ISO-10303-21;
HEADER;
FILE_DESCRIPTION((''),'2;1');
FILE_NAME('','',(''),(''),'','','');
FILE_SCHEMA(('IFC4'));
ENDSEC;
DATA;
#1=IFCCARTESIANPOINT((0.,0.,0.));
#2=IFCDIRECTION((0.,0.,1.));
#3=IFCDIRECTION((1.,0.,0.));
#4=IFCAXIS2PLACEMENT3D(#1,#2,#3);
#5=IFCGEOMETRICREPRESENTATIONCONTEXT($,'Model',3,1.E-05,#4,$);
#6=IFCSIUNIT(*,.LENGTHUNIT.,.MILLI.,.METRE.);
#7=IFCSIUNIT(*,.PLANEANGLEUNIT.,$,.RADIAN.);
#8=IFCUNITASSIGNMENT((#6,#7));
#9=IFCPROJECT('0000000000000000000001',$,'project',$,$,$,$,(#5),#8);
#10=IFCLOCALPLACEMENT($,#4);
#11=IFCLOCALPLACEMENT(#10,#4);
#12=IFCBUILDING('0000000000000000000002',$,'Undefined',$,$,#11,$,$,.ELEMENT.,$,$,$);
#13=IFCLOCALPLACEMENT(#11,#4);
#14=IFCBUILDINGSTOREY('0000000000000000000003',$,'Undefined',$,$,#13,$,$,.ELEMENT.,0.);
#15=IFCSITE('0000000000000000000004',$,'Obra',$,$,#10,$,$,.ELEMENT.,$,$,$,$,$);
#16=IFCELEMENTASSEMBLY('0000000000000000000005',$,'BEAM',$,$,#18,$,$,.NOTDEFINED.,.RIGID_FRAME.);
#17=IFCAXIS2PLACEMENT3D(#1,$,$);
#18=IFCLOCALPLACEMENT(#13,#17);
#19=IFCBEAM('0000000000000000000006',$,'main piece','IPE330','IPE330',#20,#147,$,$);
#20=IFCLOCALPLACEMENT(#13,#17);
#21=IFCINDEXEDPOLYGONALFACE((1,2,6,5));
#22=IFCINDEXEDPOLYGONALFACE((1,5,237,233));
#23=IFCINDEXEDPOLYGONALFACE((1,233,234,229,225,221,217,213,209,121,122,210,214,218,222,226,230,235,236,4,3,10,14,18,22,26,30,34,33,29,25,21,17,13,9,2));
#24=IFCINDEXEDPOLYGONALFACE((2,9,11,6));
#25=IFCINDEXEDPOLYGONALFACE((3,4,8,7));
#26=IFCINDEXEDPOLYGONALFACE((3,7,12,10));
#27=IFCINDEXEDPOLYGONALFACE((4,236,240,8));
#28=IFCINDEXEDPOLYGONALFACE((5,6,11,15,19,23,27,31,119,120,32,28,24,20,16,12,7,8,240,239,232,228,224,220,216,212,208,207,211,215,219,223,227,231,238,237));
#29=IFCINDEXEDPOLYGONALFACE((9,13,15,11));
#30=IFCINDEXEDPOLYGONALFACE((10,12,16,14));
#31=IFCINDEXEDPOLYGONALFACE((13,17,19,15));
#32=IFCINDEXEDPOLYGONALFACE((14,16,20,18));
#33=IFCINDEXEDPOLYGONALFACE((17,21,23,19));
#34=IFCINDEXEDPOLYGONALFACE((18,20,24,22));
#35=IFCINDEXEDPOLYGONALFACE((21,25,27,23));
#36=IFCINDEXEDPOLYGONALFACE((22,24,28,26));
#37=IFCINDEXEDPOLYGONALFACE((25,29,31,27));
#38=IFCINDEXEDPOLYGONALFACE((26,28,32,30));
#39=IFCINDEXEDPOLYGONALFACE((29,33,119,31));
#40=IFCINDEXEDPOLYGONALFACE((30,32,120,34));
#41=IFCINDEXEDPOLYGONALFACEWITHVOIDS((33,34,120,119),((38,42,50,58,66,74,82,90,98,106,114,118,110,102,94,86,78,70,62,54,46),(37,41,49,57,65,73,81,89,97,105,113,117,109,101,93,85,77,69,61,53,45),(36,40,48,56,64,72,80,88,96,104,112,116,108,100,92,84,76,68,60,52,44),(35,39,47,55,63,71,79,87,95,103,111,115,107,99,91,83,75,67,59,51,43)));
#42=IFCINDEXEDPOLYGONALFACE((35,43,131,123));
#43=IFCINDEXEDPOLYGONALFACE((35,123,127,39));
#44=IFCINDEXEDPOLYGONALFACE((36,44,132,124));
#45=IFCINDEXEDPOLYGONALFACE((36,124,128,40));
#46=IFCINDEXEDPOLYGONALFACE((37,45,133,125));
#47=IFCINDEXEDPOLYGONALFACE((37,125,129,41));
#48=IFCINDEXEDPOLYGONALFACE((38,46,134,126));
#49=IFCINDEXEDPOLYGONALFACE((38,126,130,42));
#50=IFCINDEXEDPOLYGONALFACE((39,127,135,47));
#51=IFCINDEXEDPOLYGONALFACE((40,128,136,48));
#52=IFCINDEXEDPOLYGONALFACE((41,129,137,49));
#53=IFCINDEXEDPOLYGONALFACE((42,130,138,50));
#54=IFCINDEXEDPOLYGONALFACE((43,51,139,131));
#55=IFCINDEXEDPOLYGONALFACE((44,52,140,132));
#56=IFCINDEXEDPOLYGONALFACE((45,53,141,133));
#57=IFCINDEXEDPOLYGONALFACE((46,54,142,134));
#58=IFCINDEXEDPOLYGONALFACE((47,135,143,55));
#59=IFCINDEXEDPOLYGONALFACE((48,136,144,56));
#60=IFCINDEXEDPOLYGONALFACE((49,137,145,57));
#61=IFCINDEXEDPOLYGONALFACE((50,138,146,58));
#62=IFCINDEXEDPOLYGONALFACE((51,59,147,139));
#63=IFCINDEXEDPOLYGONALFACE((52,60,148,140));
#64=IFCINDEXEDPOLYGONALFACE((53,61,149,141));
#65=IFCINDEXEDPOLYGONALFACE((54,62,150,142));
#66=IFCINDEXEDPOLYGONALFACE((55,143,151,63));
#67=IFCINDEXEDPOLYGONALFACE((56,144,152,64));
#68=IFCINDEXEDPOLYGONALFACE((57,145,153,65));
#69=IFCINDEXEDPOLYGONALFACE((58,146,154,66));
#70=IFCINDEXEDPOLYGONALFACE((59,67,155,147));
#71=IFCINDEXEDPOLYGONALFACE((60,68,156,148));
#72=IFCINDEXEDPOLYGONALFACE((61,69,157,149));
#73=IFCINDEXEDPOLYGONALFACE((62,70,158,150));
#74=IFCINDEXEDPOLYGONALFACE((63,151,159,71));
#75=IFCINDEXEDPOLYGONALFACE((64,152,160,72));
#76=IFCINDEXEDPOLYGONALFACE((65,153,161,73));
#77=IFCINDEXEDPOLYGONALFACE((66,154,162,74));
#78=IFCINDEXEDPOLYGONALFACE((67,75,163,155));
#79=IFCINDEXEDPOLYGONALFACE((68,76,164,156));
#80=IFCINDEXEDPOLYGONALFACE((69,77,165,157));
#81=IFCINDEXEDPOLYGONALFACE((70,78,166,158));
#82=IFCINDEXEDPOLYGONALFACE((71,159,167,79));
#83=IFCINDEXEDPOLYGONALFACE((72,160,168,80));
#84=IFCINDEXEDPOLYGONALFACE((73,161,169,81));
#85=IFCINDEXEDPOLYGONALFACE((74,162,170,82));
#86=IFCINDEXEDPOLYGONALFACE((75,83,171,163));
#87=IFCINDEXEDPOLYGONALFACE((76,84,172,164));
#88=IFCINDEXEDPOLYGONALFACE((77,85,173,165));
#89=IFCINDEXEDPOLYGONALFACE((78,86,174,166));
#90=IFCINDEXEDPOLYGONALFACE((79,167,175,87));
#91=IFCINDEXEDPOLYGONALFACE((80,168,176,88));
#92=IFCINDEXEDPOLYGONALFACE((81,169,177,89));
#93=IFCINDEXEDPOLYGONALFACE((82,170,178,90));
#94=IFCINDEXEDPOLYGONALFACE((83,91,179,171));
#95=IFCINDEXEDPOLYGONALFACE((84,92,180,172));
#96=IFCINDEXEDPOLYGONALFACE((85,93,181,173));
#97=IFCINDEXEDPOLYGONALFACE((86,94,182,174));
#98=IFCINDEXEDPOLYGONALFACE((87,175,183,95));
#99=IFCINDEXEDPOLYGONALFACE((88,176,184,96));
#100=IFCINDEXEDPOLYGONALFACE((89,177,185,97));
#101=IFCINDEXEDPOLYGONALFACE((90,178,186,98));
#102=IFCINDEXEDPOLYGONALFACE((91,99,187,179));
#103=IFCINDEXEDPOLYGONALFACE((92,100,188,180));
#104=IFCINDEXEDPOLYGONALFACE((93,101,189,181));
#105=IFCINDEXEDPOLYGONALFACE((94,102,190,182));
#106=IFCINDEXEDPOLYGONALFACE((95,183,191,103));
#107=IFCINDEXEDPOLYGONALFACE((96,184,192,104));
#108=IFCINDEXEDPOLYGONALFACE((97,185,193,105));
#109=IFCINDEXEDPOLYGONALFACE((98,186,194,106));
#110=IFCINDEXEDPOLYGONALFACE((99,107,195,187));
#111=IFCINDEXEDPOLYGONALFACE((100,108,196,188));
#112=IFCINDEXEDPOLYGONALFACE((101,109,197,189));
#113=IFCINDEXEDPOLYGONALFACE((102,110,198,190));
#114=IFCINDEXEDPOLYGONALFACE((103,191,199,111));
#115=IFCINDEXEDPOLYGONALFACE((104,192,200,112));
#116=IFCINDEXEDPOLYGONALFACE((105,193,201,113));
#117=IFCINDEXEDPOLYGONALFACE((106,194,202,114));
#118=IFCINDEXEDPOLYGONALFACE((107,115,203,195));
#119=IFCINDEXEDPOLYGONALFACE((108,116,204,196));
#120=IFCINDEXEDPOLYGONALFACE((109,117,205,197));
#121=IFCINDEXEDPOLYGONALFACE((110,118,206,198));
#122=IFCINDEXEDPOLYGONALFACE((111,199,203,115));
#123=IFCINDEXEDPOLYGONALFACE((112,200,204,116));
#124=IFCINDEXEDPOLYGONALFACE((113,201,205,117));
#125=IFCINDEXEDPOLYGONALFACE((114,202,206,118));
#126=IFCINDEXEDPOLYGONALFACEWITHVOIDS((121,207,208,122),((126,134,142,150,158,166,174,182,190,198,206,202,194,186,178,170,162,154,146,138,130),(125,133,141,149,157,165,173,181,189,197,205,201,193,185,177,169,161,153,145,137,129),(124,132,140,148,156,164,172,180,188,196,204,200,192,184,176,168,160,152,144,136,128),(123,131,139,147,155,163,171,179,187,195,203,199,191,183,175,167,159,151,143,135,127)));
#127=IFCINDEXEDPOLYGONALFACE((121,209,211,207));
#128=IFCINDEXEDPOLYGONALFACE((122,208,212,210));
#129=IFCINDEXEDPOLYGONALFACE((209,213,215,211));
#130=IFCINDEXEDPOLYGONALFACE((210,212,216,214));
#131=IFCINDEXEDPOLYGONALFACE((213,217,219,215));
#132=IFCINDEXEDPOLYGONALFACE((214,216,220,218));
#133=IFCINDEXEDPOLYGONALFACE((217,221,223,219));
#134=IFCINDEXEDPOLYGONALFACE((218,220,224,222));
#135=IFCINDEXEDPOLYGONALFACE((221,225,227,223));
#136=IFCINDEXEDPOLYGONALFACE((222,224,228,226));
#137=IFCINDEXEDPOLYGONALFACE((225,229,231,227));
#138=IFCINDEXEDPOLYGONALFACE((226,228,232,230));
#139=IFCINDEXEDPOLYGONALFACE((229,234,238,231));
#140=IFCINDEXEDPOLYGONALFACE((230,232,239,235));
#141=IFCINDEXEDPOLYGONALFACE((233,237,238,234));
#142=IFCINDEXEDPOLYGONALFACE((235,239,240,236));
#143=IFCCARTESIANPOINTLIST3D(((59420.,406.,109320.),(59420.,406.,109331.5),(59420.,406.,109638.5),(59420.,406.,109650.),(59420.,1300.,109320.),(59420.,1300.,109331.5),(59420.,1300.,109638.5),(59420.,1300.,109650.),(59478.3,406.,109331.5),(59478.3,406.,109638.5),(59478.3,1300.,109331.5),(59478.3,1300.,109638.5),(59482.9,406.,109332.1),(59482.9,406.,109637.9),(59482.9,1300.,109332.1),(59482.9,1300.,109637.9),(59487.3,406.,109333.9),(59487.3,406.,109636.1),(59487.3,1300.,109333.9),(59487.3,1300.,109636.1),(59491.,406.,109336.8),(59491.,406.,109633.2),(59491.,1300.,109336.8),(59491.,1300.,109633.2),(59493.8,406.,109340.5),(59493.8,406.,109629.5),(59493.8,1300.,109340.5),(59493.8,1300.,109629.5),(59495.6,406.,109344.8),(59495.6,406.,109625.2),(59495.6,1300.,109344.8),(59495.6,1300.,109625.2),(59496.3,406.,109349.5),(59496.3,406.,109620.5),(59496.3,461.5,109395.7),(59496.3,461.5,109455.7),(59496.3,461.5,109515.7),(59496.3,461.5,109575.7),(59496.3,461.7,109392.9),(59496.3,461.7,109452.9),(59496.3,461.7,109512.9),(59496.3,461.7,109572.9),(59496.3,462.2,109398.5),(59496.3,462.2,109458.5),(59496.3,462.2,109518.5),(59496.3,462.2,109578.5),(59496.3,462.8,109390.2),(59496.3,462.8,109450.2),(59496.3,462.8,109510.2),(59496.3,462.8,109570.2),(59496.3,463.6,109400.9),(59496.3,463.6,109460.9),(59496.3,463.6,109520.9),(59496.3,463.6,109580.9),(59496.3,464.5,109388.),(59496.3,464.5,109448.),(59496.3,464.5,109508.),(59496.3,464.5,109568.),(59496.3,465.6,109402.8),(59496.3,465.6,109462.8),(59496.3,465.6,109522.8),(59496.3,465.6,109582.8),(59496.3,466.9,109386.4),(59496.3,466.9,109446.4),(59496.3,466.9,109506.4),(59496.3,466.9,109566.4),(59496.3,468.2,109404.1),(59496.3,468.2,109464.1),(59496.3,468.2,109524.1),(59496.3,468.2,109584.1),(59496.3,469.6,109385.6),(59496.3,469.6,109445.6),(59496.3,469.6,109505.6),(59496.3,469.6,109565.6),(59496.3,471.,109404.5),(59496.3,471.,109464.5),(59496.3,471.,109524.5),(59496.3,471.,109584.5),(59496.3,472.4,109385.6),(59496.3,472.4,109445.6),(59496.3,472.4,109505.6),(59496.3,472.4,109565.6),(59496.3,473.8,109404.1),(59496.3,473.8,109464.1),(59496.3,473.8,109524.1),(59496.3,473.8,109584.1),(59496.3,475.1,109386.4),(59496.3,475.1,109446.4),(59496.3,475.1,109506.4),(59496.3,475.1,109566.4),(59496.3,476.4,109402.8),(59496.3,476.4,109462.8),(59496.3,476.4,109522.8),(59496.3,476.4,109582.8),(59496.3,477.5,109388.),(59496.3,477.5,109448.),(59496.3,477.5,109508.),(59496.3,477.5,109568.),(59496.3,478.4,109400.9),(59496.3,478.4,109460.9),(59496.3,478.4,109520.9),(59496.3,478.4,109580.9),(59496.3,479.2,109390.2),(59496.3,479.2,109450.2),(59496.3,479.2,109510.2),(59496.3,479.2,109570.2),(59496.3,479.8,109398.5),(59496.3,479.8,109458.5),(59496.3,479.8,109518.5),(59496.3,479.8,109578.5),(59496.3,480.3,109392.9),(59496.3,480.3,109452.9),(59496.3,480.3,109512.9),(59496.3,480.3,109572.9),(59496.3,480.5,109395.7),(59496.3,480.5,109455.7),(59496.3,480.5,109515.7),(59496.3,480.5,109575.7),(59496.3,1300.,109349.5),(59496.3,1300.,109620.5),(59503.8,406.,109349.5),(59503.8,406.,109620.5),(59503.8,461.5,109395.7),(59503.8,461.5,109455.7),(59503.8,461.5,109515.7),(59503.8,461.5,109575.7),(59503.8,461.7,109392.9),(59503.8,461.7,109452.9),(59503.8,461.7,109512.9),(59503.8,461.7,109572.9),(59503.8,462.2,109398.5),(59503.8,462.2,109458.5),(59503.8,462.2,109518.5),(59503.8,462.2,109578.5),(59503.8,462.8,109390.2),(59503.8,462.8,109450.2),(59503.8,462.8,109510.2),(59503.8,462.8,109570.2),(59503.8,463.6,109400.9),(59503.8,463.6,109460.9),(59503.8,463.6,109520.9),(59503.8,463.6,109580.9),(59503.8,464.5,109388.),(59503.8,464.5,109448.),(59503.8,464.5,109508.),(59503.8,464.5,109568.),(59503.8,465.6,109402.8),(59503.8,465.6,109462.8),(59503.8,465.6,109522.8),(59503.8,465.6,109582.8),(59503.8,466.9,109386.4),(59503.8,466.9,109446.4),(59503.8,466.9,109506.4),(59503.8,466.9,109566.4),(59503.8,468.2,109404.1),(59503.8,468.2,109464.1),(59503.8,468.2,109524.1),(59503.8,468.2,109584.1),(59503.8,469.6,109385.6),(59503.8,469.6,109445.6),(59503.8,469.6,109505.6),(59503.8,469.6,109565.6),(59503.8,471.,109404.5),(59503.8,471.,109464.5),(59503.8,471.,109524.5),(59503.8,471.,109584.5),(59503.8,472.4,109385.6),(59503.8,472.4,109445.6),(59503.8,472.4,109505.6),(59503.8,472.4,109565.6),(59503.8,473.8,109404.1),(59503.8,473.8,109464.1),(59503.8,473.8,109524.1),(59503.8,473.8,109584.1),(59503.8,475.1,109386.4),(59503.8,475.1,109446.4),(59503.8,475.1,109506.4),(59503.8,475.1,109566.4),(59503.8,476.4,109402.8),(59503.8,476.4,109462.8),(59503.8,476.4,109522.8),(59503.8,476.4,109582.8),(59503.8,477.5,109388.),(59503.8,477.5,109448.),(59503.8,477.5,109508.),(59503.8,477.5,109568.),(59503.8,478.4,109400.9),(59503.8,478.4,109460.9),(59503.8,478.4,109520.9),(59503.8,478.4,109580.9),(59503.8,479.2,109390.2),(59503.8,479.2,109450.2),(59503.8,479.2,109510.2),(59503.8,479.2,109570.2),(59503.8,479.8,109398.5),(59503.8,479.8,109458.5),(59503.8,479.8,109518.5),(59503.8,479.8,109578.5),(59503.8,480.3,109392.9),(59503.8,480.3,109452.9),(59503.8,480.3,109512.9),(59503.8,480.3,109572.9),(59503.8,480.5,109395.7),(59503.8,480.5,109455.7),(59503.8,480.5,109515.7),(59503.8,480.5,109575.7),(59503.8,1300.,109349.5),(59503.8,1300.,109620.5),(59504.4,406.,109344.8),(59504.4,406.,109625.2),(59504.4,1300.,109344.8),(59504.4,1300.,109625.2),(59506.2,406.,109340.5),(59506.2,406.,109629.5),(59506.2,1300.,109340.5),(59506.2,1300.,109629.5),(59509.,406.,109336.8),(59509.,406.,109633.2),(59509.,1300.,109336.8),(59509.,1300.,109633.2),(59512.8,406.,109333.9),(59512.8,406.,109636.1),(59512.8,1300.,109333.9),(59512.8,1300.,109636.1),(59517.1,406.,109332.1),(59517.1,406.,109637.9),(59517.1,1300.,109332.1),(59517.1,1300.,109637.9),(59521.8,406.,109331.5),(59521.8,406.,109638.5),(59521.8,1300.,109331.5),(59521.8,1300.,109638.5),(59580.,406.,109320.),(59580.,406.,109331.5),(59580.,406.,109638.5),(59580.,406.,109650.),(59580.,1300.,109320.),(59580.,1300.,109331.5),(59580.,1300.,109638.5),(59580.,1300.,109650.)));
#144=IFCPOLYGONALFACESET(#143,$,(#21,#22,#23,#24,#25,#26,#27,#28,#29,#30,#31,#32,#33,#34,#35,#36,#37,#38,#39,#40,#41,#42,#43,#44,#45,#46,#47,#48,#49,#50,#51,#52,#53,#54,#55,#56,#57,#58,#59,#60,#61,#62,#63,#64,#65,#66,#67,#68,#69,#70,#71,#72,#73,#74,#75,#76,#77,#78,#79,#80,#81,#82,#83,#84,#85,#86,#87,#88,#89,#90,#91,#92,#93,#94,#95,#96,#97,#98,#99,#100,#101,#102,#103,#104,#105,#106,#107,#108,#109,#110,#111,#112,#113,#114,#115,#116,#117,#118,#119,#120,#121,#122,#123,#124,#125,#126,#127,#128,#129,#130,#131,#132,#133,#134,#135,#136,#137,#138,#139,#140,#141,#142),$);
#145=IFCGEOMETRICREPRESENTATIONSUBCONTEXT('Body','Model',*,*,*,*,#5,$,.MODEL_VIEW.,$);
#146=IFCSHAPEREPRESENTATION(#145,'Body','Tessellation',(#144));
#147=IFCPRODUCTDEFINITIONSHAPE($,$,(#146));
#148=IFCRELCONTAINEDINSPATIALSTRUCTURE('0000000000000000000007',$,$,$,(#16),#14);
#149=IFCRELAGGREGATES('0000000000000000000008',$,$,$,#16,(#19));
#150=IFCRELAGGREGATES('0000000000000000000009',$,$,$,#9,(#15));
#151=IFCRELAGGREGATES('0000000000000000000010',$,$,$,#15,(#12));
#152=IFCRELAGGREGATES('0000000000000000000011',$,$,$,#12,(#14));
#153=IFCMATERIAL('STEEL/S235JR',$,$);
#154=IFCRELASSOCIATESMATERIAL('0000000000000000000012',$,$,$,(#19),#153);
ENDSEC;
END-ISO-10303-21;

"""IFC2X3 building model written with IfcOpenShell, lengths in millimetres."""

from ifc_helpers import new_model, si_unit, frame, origin_with_axes, origin_2d_with_axis, place, context, subcontext, project, spatial, circle, i_section, extrude, clip, halfspace, source, transform, mapped, material, element, aggregate, save


model = new_model("IFC2X3")

# Units and contexts
model_context = context("Model", 3, precision=1e-05, world=origin_with_axes())
body_context = subcontext(model_context, "Body", "Model", "MODEL_VIEW")
ifc_project = project(units=[si_unit("LENGTHUNIT", "METRE", prefix="MILLI"), si_unit("PLANEANGLEUNIT", "RADIAN")], contexts=[model_context])

# Site, building, storey
site_placement = place(None, origin_with_axes())
site = spatial("IfcSite", under=ifc_project, at=site_placement, Name="Obra", CompositionType="ELEMENT")
building_placement = place(site_placement, origin_with_axes())
building = spatial("IfcBuilding", under=site, at=building_placement, Name="Undefined", CompositionType="ELEMENT")
storey_placement = place(building_placement, origin_with_axes())
storey = spatial("IfcBuildingStorey", under=building, at=storey_placement, Name="Undefined", CompositionType="ELEMENT", Elevation=0.0)

# Element assembly, beam, opening
ifc_material_1 = material(Name="STEEL/S235JR")
shared_shape_1 = source(origin_with_axes(), body_context, "Body", "SweptSolid", [
    extrude(circle(Radius=9.5, at=origin_2d_with_axis()), frame((0.0, -3.9, 0.0), z_axis=(0.0, 1.0, 0.0), x_axis=(1.0, 0.0, 0.0)), (0.0, 0.0, 1.0), 7.7),
])
assembly_1_placement = place(storey_placement, origin_with_axes())
assembly_1 = element("IfcElementAssembly", 1, at=assembly_1_placement, inside=storey, Name="BEAM", AssemblyPlace="NOTDEFINED", PredefinedType="RIGID_FRAME")
beam_1_placement = place(assembly_1_placement, frame((59500.0, 400.0, 109485.0), z_axis=(0.0, 0.0, 1.0), x_axis=(0.0, 1.0, 0.0)))
beam_1 = element("IfcBeam", 2, at=beam_1_placement, material=ifc_material_1, Name="main piece", Description="IPE330", ObjectType="IPE330", context=body_context, shape_type="Clipping", body=[
    clip(extrude(i_section(OverallWidth=160.0, OverallDepth=330.0, WebThickness=7.5, FlangeThickness=11.5, FilletRadius=18.0, at=origin_2d_with_axis()), frame((900.0, 0.0, 0.0), z_axis=(-1.0, 0.0, 0.0), x_axis=(0.0, -1.0, 0.0)), (0.0, 0.0, 1.0), 894.0), halfspace(frame((6.0, 0.0, -220.0), z_axis=(1.0, 0.0, 0.0), x_axis=(0.0, -1.0, 0.0)), True)),
])
opening_1_placement = place(assembly_1_placement, frame((59500.0, 471.0, 109395.0), z_axis=(0.0, -1.0, 0.0), x_axis=(0.0, 0.0, 1.0)))
element("IfcOpeningElement", 3, at=opening_1_placement, cuts=beam_1, ObjectType="Opening", context=body_context, shape_type="MappedRepresentation", body=[
    mapped(shared_shape_1, transform((0.0, 0.0, 0.0))),
    mapped(shared_shape_1, transform((60.0, 0.0, 0.0))),
    mapped(shared_shape_1, transform((120.0, 0.0, 0.0))),
    mapped(shared_shape_1, transform((180.0, 0.0, 0.0))),
])
aggregate(assembly_1, [beam_1])

save(model, "model.ifc")
